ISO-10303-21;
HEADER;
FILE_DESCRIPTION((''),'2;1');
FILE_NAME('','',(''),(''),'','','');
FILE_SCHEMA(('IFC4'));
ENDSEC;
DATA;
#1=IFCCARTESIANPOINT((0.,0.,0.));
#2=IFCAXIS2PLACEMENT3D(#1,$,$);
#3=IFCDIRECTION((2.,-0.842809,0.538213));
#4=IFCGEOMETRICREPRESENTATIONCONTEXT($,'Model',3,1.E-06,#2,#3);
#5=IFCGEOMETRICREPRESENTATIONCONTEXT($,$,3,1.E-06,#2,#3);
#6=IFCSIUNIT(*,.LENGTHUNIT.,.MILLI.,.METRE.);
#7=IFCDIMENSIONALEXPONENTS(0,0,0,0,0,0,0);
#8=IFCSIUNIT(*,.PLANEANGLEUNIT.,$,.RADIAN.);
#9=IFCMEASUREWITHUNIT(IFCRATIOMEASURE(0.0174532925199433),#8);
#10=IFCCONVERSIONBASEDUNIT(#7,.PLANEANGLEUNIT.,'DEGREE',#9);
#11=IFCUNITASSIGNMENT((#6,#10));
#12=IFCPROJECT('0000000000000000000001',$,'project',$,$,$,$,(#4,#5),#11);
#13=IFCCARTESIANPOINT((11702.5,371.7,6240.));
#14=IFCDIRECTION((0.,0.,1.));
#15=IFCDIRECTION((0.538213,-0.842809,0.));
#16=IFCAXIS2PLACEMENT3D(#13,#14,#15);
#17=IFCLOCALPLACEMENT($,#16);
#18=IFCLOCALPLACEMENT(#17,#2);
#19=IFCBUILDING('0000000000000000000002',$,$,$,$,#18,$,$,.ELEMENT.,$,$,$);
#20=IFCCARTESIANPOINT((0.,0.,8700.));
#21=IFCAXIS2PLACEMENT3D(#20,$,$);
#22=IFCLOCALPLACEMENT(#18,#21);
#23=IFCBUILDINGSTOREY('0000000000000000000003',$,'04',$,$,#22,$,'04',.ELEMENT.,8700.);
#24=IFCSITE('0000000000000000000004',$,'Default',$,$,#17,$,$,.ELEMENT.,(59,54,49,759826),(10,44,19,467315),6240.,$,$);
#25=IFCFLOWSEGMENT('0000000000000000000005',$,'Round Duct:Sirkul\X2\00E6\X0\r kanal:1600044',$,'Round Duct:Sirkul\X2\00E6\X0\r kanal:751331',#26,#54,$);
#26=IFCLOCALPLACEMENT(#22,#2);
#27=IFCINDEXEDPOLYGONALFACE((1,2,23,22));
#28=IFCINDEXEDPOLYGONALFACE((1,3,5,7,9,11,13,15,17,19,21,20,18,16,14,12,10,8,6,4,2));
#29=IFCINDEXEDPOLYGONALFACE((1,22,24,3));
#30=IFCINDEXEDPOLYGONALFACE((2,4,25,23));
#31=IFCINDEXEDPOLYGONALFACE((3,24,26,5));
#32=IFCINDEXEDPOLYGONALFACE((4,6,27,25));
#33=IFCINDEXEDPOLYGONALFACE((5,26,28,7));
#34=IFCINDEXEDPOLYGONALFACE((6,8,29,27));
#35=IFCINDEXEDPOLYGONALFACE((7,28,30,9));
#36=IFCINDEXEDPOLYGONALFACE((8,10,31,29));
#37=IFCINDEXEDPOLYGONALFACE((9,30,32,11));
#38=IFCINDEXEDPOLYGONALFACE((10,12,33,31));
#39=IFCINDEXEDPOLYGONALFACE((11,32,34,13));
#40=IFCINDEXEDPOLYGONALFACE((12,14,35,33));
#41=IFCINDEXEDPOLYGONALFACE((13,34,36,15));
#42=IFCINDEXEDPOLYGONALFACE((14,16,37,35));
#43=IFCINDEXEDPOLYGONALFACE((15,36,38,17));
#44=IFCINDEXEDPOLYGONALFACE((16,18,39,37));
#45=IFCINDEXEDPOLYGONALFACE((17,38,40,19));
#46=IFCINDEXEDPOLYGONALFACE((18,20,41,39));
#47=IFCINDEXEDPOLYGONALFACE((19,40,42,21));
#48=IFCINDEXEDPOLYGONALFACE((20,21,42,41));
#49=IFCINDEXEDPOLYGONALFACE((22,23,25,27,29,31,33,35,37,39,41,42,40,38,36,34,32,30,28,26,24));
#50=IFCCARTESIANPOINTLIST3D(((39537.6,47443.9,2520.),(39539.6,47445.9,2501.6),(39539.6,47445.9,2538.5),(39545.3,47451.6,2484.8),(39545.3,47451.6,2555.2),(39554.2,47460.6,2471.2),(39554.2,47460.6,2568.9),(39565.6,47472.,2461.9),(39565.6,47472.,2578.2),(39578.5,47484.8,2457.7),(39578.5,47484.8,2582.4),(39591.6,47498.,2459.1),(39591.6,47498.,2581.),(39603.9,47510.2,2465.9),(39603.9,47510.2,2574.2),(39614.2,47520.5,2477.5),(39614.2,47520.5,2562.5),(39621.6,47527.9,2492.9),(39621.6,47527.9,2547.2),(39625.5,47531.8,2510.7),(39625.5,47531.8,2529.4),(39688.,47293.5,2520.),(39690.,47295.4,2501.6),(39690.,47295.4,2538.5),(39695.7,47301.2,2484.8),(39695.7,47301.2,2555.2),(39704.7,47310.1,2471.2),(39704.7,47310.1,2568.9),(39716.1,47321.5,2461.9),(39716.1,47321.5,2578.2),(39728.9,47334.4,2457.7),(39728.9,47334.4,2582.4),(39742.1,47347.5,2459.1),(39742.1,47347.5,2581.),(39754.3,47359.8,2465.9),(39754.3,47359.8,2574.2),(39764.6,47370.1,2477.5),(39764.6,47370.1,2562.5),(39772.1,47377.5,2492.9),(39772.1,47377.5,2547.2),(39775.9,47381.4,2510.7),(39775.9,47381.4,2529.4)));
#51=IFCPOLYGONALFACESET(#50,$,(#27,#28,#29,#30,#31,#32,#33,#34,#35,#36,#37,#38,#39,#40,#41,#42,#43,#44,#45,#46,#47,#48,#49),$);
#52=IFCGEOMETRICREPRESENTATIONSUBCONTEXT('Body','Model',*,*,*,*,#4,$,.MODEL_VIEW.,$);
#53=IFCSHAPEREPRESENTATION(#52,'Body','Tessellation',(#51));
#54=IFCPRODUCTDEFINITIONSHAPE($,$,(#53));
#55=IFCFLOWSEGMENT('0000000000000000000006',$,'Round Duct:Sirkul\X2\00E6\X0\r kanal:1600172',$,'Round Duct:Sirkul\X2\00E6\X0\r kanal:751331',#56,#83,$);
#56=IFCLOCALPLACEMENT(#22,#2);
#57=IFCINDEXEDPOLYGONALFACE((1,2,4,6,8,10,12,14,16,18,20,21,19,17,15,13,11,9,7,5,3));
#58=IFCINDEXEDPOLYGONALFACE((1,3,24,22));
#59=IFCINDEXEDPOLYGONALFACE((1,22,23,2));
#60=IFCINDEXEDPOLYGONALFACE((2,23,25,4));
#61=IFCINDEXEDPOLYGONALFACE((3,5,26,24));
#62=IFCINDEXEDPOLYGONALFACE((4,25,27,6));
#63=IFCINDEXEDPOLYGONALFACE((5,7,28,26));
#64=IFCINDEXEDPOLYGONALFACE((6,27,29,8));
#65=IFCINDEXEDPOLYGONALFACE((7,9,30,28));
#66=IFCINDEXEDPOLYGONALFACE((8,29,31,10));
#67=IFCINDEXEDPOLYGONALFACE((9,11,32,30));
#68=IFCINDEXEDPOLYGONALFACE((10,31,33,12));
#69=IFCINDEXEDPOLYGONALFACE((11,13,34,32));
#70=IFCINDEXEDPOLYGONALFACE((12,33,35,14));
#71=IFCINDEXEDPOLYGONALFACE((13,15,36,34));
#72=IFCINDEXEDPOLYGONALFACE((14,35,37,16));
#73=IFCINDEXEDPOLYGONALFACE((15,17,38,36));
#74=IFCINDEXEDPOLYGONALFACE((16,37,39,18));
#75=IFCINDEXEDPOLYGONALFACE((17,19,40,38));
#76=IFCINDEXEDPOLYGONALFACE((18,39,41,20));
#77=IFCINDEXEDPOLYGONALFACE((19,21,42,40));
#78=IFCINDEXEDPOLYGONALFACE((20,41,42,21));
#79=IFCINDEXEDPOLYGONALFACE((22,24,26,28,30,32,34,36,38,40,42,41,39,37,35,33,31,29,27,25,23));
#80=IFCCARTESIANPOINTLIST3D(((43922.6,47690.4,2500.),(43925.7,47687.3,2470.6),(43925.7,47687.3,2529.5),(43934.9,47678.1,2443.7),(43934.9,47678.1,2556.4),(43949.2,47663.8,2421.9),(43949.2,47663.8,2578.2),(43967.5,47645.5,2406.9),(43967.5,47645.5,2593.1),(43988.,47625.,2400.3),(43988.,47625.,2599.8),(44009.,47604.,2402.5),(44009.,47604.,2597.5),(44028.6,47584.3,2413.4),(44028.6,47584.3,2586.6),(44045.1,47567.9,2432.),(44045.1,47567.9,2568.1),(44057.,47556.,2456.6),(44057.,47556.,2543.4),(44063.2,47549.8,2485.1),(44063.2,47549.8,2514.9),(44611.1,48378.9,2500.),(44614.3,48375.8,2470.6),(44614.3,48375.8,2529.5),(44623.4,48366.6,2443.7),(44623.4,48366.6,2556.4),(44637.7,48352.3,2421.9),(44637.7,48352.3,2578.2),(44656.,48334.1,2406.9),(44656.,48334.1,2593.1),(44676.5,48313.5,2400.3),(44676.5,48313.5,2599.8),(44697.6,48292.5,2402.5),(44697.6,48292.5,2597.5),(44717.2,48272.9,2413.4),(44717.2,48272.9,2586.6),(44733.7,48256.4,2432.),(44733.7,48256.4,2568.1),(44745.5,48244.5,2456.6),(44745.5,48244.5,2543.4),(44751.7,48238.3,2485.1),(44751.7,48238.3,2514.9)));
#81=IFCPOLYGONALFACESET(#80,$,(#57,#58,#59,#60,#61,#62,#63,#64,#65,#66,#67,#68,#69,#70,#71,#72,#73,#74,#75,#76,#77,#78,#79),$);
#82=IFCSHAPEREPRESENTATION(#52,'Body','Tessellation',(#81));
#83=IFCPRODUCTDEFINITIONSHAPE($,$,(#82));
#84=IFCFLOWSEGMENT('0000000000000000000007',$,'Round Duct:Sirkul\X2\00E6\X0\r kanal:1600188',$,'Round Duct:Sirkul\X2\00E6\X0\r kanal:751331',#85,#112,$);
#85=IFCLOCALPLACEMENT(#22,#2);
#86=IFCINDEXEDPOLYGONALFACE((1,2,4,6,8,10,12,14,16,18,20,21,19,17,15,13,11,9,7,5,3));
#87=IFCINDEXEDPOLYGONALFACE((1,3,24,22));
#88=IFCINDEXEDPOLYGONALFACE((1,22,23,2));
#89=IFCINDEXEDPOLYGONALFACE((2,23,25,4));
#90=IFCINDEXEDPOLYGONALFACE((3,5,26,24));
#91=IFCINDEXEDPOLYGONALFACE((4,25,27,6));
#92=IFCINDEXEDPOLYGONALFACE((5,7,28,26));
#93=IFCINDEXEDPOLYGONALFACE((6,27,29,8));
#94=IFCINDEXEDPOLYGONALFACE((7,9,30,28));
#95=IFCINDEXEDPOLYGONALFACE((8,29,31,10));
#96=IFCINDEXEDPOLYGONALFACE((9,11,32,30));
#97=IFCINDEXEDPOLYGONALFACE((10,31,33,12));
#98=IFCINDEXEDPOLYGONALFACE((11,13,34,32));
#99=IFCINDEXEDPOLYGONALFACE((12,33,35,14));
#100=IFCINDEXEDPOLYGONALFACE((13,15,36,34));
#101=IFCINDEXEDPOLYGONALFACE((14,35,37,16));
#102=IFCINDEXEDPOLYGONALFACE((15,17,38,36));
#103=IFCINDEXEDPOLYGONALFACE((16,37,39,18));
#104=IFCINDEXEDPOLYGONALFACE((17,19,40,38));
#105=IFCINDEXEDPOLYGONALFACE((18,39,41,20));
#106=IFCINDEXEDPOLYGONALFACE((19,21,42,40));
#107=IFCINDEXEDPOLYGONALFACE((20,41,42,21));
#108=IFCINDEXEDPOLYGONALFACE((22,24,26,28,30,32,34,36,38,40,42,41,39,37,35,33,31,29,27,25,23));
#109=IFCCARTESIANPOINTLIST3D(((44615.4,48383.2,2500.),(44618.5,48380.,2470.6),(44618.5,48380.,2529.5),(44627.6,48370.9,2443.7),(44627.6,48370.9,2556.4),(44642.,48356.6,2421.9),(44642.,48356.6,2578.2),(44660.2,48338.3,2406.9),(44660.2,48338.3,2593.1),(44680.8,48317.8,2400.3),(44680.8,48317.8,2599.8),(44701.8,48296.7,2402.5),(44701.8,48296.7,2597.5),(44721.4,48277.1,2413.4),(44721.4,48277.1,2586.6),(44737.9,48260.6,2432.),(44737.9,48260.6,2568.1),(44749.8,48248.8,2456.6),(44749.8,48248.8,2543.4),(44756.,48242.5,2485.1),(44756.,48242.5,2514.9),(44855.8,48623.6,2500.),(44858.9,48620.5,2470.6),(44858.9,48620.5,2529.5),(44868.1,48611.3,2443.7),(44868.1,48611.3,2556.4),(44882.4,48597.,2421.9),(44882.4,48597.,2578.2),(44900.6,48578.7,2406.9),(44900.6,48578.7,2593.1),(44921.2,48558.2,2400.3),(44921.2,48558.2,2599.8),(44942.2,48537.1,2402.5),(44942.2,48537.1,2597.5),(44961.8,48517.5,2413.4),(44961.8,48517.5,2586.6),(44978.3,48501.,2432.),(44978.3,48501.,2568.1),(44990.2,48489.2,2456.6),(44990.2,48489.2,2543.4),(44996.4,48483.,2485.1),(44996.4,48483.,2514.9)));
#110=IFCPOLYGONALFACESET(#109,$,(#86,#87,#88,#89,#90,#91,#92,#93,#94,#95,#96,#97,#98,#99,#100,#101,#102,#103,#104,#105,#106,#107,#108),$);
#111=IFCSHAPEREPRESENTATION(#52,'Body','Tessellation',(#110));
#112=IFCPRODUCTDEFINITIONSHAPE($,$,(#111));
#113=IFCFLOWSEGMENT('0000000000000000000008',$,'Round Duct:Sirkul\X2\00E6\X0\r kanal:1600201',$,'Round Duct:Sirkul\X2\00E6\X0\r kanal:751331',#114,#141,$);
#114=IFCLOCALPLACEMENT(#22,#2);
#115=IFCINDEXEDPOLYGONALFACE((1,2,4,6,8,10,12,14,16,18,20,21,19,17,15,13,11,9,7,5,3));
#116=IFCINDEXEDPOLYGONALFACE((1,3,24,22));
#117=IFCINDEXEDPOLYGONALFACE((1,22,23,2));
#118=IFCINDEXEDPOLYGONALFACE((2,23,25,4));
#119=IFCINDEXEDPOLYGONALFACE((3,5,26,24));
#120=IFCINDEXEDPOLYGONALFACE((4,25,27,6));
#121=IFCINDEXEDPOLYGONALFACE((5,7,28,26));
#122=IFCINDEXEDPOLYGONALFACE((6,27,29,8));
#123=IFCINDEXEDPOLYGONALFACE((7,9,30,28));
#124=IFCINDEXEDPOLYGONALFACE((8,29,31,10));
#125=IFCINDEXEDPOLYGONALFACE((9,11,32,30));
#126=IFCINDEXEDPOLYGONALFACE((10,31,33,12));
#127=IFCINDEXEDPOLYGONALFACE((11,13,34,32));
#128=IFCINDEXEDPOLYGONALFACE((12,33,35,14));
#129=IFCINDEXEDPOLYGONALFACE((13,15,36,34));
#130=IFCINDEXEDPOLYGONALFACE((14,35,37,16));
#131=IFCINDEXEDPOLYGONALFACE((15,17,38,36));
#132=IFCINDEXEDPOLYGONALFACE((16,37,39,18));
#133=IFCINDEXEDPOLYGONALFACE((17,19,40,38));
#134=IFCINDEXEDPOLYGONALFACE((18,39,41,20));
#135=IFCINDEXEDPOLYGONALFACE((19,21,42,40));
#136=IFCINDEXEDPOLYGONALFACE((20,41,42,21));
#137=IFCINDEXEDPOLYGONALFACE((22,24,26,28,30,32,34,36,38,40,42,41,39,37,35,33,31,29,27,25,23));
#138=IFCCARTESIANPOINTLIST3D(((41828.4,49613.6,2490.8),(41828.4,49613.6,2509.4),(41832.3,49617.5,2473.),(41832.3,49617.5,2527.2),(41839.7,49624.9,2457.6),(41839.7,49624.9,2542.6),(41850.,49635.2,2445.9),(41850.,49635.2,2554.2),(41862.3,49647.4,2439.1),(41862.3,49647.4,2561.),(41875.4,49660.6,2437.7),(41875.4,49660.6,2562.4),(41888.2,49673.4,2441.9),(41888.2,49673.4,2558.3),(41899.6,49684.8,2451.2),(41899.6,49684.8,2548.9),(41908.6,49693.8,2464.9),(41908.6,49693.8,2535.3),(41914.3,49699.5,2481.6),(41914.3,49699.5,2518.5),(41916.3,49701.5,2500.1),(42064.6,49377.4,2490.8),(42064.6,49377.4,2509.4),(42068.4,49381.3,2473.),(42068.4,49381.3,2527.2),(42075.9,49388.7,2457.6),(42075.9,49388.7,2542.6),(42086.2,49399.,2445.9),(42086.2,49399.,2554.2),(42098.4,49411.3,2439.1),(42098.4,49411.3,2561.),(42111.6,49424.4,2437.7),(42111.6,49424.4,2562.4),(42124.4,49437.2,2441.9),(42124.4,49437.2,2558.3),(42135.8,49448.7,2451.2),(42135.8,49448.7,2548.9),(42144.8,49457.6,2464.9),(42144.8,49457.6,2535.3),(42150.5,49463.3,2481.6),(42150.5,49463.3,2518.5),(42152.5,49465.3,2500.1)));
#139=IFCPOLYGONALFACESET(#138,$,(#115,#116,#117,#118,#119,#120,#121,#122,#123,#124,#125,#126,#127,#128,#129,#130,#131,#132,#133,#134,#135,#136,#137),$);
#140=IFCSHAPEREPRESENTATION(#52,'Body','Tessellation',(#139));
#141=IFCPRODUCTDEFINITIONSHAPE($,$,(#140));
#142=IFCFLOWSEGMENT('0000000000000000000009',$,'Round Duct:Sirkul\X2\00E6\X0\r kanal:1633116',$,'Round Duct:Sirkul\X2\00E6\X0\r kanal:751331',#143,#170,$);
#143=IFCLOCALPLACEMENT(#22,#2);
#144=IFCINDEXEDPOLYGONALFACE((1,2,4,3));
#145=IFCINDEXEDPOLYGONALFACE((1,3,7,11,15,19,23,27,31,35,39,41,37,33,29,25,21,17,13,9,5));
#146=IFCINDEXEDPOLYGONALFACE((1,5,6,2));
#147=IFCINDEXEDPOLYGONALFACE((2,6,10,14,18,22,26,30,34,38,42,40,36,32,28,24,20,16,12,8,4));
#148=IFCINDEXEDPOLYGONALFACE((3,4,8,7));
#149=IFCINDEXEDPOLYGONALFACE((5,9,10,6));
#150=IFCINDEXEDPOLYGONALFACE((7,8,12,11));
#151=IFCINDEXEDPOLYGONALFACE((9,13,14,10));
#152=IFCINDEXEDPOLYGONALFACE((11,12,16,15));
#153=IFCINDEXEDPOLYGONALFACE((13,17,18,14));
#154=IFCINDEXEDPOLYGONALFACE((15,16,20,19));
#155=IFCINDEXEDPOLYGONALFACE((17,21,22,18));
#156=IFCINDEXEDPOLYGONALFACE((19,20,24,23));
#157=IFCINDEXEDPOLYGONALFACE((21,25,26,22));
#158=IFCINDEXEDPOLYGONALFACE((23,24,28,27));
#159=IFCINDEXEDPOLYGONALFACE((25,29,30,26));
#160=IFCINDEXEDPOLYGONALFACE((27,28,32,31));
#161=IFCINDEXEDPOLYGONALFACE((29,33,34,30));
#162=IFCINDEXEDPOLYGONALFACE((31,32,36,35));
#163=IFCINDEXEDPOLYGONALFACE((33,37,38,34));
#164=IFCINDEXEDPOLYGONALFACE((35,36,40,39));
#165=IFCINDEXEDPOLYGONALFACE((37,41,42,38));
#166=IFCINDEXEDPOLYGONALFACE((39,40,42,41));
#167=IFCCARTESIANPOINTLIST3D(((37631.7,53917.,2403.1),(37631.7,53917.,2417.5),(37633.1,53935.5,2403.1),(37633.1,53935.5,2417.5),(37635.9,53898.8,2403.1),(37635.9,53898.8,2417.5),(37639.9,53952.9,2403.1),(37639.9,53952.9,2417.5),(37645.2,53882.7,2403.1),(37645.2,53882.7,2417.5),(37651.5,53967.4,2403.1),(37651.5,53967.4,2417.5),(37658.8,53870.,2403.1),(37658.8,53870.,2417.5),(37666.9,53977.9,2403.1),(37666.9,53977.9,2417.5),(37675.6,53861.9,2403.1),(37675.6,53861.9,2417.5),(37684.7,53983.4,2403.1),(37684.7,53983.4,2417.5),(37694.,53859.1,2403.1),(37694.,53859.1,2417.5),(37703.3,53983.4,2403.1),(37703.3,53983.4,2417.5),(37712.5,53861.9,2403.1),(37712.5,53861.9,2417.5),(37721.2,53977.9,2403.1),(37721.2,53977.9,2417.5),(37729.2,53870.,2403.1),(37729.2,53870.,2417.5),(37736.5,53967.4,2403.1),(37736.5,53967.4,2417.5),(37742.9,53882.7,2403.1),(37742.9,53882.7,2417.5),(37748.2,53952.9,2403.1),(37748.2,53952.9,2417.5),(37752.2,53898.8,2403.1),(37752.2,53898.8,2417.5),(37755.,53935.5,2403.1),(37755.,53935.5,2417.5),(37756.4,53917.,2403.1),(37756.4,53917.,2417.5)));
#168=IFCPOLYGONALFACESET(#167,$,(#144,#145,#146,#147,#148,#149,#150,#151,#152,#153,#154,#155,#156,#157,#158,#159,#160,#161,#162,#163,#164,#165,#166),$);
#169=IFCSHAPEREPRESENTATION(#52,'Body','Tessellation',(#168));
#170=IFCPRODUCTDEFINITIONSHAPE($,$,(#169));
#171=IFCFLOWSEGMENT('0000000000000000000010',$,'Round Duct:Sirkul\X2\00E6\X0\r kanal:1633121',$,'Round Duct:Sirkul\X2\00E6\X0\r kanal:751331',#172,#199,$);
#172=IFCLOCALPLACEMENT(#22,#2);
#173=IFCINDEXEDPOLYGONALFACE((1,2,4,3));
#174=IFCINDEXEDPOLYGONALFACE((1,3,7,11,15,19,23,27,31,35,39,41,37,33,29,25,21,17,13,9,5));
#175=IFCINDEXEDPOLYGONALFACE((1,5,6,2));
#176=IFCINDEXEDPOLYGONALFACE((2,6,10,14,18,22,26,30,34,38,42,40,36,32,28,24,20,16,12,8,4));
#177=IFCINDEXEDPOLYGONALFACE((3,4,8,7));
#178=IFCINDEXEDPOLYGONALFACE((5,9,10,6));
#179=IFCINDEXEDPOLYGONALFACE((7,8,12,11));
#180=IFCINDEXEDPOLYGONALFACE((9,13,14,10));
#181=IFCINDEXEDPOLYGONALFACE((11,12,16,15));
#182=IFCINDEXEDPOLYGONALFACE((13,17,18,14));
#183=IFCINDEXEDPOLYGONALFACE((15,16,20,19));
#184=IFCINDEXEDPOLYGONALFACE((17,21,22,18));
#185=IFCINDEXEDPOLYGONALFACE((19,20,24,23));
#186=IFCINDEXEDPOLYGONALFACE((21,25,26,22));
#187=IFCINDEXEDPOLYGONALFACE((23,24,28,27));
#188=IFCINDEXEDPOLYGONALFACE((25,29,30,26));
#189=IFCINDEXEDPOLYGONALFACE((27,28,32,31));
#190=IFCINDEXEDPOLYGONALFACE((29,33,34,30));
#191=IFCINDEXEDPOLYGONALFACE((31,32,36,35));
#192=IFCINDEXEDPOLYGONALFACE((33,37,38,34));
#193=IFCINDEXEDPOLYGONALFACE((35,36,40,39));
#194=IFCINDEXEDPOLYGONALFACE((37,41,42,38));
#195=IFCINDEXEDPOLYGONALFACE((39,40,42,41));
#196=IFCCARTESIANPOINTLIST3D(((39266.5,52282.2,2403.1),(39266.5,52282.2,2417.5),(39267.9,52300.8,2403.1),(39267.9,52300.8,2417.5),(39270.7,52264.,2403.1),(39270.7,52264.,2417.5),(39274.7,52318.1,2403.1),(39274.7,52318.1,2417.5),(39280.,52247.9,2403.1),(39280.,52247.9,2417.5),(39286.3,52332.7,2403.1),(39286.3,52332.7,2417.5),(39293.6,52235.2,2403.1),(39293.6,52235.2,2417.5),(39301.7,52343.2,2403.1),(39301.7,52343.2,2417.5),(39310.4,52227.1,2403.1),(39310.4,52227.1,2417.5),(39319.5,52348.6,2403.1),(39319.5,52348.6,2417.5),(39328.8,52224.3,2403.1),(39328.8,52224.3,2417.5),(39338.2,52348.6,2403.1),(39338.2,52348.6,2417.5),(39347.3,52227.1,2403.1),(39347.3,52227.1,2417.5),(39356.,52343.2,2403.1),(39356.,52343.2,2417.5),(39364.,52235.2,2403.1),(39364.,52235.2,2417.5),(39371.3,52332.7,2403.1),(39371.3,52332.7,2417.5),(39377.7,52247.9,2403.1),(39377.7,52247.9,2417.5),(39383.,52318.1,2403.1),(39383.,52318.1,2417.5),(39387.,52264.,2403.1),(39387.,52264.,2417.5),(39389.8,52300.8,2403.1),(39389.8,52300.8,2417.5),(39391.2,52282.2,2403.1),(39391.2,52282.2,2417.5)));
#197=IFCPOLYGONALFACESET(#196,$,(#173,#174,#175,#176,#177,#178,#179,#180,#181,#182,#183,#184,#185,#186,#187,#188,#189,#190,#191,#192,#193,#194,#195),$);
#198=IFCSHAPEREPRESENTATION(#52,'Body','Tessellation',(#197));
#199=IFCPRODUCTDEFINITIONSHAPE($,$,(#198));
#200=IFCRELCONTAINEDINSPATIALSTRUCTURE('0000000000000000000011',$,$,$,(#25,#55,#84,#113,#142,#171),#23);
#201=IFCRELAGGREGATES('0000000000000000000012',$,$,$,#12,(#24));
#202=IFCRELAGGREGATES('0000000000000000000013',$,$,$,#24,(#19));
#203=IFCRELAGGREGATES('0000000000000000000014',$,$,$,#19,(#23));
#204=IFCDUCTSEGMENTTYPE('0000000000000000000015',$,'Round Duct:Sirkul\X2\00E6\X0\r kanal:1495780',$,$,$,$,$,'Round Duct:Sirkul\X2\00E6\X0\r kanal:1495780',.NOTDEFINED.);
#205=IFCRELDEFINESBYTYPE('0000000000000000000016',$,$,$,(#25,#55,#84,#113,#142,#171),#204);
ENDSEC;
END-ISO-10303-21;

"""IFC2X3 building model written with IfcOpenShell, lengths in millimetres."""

from ifc_helpers import new_model, entity, si_unit, converted_unit, direction, frame, frame_2d, origin, origin_2d_with_axis, place, context, subcontext, project, spatial, circle, extrude, type_object, element, save


model = new_model("IFC2X3")

# Units and contexts
model_context = context("Model", 3, precision=1e-06, world=origin(), true_north=direction((2.0, -0.842809, 0.538213)))
context_of_model = context(None, 3, precision=1e-06, world=origin(), true_north=direction((2.0, -0.842809, 0.538213)))
body_context = subcontext(model_context, "Body", "Model", "MODEL_VIEW")
ifc_project = project(units=[si_unit("LENGTHUNIT", "METRE", prefix="MILLI"), converted_unit("PLANEANGLEUNIT", "DEGREE", entity("IfcRatioMeasure", 0.0174532925199433), si_unit("PLANEANGLEUNIT", "RADIAN"), dimensions=[0, 0, 0, 0, 0, 0, 0])], contexts=[model_context, context_of_model])

# Site, building, storey
site_placement = place(None, frame((11702.5, 371.7, 6240.0), z_axis=(0.0, 0.0, 1.0), x_axis=(0.538213, -0.842809, 0.0)))
site = spatial("IfcSite", under=ifc_project, at=site_placement, Name="Default", CompositionType="ELEMENT", RefLatitude=(59, 54, 49, 759826), RefLongitude=(10, 44, 19, 467315), RefElevation=6240.0)
building_placement = place(site_placement, origin())
building = spatial("IfcBuilding", under=site, at=building_placement, CompositionType="ELEMENT")
storey_placement = place(building_placement, frame((0.0, 0.0, 8700.0)))
storey = spatial("IfcBuildingStorey", under=building, at=storey_placement, Name="04", LongName="04", CompositionType="ELEMENT", Elevation=8700.0)

# Flow segments
duct_segment_type = type_object("IfcDuctSegmentType", Name="Round Duct:Sirkulær kanal:1495780", ElementType="Round Duct:Sirkulær kanal:1495780", PredefinedType="NOTDEFINED")
flow_segment_1_placement = place(storey_placement, origin())
element("IfcFlowSegment", 1, at=flow_segment_1_placement, inside=storey, type_object=duct_segment_type, Name="Round Duct:Sirkulær kanal:1600044", ObjectType="Round Duct:Sirkulær kanal:751331", context=body_context, shape_type="SweptSolid", body=[
    extrude(circle(Radius=62.5, at=origin_2d_with_axis()), frame((39581.8, 47488.1, 2520.0), z_axis=(0.707107, -0.707107, 0.0), x_axis=(-0.707107, -0.707107, 0.0)), (0.0, 0.0, 1.0), 212.8),
])
flow_segment_2_placement = place(storey_placement, origin())
element("IfcFlowSegment", 2, at=flow_segment_2_placement, inside=storey, type_object=duct_segment_type, Name="Round Duct:Sirkulær kanal:1600172", ObjectType="Round Duct:Sirkulær kanal:751331", context=body_context, shape_type="SweptSolid", body=[
    extrude(circle(Radius=100.0, at=origin_2d_with_axis()), frame((43993.3, 47619.7, 2500.0), z_axis=(0.707107, 0.707107, 0.0), x_axis=(-0.707107, 0.707107, 0.0)), (0.0, 0.0, 1.0), 973.7),
])
flow_segment_3_placement = place(storey_placement, origin())
element("IfcFlowSegment", 3, at=flow_segment_3_placement, inside=storey, type_object=duct_segment_type, Name="Round Duct:Sirkulær kanal:1600188", ObjectType="Round Duct:Sirkulær kanal:751331", context=body_context, shape_type="SweptSolid", body=[
    extrude(circle(Radius=100.0, at=origin_2d_with_axis()), frame((44686.1, 48312.5, 2500.0), z_axis=(0.707107, 0.707107, 0.0), x_axis=(-0.707107, 0.707107, 0.0)), (0.0, 0.0, 1.0), 340.0),
])
flow_segment_4_placement = place(storey_placement, origin())
element("IfcFlowSegment", 4, at=flow_segment_4_placement, inside=storey, type_object=duct_segment_type, Name="Round Duct:Sirkulær kanal:1600201", ObjectType="Round Duct:Sirkulær kanal:751331", context=body_context, shape_type="SweptSolid", body=[
    extrude(circle(Radius=62.5, at=origin_2d_with_axis()), frame((41872.1, 49657.3, 2500.1), z_axis=(0.707107, -0.707107, 0.0), x_axis=(0.707107, 0.707107, 0.0)), (0.0, 0.0, 1.0), 334.0),
])
flow_segment_5_placement = place(building_placement, frame((0.0, 0.0, 8700.0)))
element("IfcFlowSegment", 5, at=flow_segment_5_placement, inside=storey, type_object=duct_segment_type, Name="Round Duct:Sirkulær kanal:1633116", ObjectType="Round Duct:Sirkulær kanal:751331", context=body_context, shape_type="SweptSolid", body=[
    extrude(circle(Radius=62.5, at=frame_2d((0.0, 0.0), x_axis=(1.0, 0.0))), frame((37694.0, 53921.6, 2403.1), z_axis=(0.0, 0.0, 1.0), x_axis=(0.0, -1.0, 0.0)), (0.0, 0.0, 1.0), 14.4),
])
flow_segment_6_placement = place(building_placement, frame((0.0, 0.0, 8700.0)))
element("IfcFlowSegment", 6, at=flow_segment_6_placement, inside=storey, type_object=duct_segment_type, Name="Round Duct:Sirkulær kanal:1633121", ObjectType="Round Duct:Sirkulær kanal:751331", context=body_context, shape_type="SweptSolid", body=[
    extrude(circle(Radius=62.5, at=frame_2d((0.0, 0.0), x_axis=(1.0, 0.0))), frame((39328.8, 52286.8, 2403.1), z_axis=(0.0, 0.0, 1.0), x_axis=(0.0, -1.0, 0.0)), (0.0, 0.0, 1.0), 14.4),
])

save(model, "model.ifc")
